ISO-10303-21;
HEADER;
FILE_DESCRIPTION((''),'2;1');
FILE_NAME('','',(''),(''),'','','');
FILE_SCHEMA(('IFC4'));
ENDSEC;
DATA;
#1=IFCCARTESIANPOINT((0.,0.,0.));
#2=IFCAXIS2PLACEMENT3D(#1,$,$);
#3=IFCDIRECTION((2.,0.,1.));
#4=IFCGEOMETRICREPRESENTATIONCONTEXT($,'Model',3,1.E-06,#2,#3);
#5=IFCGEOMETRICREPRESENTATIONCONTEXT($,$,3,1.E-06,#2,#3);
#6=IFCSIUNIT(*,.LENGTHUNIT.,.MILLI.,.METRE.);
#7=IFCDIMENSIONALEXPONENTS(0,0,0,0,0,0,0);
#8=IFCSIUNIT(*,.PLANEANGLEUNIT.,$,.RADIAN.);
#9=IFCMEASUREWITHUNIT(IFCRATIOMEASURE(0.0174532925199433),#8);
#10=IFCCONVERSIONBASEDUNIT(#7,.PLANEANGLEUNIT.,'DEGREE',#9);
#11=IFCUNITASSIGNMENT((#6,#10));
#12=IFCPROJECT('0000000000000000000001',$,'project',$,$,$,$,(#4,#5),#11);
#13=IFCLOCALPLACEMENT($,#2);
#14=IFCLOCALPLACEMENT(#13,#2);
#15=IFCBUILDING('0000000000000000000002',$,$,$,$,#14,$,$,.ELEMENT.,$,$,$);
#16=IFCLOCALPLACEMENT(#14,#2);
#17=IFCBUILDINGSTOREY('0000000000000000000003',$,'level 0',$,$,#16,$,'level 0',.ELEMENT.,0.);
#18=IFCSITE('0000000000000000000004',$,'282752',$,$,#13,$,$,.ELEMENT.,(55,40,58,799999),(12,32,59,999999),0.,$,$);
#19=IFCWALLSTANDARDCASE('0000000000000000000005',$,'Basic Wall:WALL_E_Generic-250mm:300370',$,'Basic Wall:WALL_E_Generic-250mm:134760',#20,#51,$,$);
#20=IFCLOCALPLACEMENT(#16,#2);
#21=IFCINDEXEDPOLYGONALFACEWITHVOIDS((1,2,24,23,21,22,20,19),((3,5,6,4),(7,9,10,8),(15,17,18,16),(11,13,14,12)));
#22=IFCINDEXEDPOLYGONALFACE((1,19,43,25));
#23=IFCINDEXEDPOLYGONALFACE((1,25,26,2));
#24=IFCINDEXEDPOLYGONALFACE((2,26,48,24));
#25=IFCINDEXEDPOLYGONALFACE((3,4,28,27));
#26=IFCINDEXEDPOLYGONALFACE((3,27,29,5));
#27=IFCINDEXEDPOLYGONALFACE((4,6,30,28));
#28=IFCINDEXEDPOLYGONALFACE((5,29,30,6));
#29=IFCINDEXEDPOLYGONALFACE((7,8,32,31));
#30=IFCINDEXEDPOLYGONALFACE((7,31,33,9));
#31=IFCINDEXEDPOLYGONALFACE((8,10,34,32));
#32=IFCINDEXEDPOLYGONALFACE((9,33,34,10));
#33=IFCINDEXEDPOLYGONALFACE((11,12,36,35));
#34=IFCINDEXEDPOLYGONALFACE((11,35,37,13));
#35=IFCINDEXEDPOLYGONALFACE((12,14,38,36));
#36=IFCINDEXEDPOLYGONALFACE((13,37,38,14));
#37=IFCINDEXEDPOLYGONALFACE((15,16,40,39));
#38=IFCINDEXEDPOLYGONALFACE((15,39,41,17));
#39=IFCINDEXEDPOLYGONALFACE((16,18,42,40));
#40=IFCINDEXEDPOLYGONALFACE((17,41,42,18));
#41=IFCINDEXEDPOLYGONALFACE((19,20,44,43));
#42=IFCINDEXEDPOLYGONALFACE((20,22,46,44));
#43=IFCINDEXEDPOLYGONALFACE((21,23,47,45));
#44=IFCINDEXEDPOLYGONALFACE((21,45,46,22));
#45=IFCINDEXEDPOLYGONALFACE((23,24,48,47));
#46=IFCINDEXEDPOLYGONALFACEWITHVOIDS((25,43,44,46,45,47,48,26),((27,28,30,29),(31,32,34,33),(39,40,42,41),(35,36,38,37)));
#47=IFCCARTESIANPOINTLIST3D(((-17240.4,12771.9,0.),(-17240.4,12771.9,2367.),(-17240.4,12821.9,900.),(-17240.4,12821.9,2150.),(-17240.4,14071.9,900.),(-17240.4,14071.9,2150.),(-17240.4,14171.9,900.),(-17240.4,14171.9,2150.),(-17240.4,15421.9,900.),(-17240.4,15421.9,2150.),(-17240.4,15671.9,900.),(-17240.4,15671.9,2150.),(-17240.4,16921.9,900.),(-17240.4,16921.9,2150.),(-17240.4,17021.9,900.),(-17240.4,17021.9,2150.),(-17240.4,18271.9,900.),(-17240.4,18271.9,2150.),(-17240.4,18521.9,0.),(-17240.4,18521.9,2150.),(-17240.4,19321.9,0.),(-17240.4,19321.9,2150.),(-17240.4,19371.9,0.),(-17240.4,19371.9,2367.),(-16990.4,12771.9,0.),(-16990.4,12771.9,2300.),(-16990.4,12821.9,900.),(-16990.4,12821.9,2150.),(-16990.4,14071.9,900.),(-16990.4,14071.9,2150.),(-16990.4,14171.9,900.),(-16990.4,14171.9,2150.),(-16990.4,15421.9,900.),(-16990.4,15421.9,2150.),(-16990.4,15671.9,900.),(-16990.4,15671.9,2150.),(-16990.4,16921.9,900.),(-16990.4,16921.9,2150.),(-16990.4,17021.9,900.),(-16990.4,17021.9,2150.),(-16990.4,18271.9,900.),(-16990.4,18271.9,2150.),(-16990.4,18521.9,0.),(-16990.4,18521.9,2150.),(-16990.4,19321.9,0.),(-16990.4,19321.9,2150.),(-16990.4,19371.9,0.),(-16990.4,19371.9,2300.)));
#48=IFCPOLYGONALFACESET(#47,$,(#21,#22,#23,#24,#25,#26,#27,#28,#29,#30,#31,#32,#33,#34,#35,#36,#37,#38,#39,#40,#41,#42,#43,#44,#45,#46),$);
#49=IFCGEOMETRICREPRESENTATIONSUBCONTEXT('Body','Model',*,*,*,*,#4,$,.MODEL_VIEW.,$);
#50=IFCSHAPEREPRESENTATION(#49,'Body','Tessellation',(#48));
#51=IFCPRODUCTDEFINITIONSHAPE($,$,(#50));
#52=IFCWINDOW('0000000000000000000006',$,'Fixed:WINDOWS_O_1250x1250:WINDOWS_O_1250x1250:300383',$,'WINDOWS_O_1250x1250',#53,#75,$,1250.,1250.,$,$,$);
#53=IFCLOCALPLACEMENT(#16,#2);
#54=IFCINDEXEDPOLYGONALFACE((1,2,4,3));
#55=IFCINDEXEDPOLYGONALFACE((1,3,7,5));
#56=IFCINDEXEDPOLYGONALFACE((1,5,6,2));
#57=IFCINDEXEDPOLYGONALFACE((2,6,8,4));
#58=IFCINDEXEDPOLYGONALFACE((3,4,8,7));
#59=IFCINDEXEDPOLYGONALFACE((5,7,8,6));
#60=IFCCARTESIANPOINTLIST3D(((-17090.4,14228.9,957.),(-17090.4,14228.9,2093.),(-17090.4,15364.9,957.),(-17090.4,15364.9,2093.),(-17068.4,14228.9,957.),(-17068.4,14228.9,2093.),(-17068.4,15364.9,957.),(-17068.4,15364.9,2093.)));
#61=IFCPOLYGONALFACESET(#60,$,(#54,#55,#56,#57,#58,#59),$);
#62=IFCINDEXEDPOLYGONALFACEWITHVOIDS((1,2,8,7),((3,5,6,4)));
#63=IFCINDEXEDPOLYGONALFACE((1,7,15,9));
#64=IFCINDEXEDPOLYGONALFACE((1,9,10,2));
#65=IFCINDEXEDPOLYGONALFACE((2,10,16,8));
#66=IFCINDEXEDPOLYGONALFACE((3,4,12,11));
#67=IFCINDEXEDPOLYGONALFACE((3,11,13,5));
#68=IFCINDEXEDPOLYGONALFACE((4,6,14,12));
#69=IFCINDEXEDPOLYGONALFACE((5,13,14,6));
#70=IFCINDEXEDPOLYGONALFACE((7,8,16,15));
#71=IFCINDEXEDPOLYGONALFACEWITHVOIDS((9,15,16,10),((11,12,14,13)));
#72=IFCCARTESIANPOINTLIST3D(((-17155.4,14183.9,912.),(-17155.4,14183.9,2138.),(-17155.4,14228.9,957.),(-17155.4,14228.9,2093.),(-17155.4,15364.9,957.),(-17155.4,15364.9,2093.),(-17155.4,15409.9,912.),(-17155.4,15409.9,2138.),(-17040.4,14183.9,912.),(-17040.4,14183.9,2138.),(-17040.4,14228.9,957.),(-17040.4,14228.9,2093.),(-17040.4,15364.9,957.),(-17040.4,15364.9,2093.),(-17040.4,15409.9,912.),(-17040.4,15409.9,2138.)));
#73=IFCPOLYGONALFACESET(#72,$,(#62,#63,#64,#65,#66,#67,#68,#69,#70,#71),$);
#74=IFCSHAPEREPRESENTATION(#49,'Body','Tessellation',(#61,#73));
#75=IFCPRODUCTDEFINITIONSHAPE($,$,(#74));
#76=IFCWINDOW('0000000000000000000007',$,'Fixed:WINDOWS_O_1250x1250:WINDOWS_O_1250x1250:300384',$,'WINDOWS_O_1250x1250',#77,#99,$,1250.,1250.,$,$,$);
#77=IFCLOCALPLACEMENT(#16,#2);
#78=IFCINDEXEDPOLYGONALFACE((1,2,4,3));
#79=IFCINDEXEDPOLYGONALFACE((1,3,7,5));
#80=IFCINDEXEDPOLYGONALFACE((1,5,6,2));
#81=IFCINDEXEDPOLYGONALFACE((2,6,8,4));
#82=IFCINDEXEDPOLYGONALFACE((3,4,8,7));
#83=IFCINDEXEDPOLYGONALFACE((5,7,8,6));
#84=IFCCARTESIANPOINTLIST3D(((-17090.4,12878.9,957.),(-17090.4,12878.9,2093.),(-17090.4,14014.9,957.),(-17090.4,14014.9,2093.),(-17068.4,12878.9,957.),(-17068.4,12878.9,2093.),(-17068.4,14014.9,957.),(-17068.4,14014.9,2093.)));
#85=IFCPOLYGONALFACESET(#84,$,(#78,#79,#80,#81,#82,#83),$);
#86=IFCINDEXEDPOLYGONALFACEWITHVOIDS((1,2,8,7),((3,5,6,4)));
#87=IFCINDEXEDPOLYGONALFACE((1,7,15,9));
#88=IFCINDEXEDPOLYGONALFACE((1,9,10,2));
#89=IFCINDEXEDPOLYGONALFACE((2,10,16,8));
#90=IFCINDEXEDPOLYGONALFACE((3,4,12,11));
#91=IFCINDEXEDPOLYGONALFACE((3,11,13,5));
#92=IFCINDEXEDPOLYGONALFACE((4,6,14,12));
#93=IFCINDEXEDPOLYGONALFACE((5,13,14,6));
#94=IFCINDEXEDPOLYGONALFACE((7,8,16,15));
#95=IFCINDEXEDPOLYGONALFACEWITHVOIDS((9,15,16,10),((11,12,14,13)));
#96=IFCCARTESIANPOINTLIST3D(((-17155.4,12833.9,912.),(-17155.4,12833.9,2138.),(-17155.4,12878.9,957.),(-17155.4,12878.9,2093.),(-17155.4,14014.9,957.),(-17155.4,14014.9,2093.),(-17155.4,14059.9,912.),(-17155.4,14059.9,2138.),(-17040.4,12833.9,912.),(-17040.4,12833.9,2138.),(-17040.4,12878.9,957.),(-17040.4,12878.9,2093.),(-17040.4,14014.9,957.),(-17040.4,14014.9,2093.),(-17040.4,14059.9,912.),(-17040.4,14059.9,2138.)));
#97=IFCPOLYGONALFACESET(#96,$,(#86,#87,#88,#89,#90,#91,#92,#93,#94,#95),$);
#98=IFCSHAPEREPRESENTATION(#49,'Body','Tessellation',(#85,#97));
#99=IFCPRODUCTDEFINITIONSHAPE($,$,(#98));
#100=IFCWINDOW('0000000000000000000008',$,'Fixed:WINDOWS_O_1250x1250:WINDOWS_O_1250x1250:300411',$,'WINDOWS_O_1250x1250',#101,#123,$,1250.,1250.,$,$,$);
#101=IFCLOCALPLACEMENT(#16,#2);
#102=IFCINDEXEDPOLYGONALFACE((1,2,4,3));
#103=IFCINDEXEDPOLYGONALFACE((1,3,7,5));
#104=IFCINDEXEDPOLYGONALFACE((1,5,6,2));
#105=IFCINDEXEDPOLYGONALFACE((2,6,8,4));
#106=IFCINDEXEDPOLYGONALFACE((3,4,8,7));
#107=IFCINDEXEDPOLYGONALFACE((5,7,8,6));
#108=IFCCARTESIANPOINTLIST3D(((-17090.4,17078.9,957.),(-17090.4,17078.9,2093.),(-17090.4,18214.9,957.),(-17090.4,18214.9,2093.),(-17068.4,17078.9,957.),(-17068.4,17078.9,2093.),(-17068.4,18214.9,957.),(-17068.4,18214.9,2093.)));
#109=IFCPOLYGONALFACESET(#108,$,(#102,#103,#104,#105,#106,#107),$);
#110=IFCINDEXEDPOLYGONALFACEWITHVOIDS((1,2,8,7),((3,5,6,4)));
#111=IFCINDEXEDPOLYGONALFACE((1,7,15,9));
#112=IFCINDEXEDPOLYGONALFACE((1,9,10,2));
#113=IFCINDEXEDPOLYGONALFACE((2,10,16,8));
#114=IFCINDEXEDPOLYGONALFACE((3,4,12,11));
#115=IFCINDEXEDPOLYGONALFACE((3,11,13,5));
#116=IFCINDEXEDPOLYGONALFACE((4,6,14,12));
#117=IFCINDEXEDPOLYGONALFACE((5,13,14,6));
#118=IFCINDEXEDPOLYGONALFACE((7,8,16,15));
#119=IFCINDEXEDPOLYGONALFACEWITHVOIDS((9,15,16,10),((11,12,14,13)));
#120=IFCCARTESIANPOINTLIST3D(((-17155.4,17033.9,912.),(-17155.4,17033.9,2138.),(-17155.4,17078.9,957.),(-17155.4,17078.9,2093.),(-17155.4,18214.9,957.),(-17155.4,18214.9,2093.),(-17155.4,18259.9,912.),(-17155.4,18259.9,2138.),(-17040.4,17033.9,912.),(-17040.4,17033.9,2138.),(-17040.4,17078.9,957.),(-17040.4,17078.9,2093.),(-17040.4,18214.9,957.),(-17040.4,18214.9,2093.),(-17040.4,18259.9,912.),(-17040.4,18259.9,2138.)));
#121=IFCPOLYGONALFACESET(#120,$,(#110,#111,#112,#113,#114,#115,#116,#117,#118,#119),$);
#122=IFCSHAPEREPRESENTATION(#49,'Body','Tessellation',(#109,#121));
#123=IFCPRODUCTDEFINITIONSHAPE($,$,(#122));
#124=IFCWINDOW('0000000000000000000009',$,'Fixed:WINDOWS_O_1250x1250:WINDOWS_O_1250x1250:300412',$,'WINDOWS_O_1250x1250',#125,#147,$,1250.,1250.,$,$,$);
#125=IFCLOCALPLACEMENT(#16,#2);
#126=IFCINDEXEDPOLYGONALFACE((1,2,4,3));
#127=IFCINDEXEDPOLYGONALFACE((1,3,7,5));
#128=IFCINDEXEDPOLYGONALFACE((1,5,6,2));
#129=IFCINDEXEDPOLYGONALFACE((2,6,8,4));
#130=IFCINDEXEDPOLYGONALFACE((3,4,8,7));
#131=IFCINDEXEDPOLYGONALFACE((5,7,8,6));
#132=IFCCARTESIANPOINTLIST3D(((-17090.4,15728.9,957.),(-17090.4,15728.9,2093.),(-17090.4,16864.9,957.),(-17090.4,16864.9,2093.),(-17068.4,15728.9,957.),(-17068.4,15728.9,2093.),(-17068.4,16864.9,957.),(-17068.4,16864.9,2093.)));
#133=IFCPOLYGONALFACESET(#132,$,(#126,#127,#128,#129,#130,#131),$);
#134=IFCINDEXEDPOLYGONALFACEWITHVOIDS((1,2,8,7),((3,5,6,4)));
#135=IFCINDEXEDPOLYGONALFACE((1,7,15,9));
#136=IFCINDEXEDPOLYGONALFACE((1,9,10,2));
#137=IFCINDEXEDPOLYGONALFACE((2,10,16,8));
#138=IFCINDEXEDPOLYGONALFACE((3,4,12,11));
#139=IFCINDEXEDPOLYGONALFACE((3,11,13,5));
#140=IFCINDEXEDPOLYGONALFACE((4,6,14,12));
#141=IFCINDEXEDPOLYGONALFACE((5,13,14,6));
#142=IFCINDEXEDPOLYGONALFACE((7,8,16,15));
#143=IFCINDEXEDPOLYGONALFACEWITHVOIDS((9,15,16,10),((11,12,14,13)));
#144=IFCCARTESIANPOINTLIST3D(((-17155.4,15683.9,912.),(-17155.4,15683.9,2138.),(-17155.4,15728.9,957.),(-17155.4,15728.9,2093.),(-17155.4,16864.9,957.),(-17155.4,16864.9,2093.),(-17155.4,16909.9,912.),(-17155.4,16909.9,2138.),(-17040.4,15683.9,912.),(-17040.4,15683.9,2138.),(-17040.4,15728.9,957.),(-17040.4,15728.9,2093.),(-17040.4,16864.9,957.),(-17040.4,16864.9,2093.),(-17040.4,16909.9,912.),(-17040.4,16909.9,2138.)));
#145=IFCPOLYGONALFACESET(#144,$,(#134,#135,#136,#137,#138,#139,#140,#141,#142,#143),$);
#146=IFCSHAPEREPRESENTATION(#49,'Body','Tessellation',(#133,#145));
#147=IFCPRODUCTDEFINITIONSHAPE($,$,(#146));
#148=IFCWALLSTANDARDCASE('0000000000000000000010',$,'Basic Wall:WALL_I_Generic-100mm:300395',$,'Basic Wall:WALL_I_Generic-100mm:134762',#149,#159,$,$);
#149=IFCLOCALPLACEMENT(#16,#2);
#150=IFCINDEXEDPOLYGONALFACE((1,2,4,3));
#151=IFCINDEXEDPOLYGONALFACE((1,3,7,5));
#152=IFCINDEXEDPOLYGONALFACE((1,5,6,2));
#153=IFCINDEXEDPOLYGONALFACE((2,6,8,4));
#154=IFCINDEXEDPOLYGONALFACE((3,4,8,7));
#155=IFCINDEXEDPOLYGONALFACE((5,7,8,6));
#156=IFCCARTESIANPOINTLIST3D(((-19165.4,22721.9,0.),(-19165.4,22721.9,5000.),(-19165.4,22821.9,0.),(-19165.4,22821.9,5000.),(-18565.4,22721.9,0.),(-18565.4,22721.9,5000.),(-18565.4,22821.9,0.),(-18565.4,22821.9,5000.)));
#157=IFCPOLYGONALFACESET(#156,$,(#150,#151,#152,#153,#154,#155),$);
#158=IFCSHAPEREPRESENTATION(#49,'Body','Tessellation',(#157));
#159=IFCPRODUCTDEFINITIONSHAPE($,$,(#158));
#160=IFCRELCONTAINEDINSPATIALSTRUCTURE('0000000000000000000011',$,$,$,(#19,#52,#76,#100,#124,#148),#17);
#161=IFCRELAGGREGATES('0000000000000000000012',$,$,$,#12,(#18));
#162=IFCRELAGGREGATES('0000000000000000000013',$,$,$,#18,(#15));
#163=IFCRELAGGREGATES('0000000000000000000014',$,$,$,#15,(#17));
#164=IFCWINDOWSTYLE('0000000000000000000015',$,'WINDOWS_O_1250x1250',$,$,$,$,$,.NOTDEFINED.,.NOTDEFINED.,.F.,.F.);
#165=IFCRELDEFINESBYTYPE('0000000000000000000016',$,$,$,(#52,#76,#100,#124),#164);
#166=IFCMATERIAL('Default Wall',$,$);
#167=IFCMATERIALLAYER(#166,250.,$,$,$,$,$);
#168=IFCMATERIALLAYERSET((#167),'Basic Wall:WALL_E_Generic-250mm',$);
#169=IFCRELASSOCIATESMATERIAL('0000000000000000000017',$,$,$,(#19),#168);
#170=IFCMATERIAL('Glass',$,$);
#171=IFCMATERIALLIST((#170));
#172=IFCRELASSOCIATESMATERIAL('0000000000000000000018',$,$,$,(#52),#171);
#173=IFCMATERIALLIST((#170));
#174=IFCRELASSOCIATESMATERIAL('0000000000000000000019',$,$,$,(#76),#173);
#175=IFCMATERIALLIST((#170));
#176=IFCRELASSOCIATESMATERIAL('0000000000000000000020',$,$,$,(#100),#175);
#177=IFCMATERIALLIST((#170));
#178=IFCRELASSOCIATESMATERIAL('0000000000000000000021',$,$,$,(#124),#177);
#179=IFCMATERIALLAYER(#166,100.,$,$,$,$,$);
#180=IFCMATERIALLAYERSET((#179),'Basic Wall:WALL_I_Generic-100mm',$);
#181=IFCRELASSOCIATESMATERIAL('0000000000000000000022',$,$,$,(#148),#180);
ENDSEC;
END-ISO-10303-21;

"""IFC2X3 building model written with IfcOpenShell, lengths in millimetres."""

from ifc_helpers import new_model, entity, si_unit, converted_unit, direction, frame, frame_2d, origin, origin_2d_with_axis, place, context, subcontext, project, spatial, polyline, rectangle, outline, extrude, clip, bounded_halfspace, source, transform, mapped, material, material_list, layer, layer_set, layer_usage, type_object, type_shapes, element, fill, save


model = new_model("IFC2X3")

# Units and contexts
model_context = context("Model", 3, precision=1e-06, world=origin(), true_north=direction((2.0, 0.0, 1.0)))
context_of_model = context(None, 3, precision=1e-06, world=origin(), true_north=direction((2.0, 0.0, 1.0)))
body_context = subcontext(model_context, "Body", "Model", "MODEL_VIEW")
ifc_project = project(units=[si_unit("LENGTHUNIT", "METRE", prefix="MILLI"), converted_unit("PLANEANGLEUNIT", "DEGREE", entity("IfcRatioMeasure", 0.0174532925199433), si_unit("PLANEANGLEUNIT", "RADIAN"), dimensions=[0, 0, 0, 0, 0, 0, 0])], contexts=[model_context, context_of_model])

# Site, building, storey
site_placement = place(None, origin())
site = spatial("IfcSite", under=ifc_project, at=site_placement, Name="282752", CompositionType="ELEMENT", RefLatitude=(55, 40, 58, 799999), RefLongitude=(12, 32, 59, 999999), RefElevation=0.0)
building_placement = place(site_placement, origin())
building = spatial("IfcBuilding", under=site, at=building_placement, CompositionType="ELEMENT")
storey_placement = place(building_placement, origin())
storey = spatial("IfcBuildingStorey", under=building, at=storey_placement, Name="level 0", LongName="level 0", CompositionType="ELEMENT", Elevation=0.0)

# Shared definitions
ifc_material_1 = material(Name="Default Wall")
ifc_layer_1 = layer(ifc_material_1, 100.0)
ifc_layer_set_1 = layer_set([ifc_layer_1], Name="Basic Wall:WALL_I_Generic-100mm")

# Shared definitions
ifc_layer_2 = layer(ifc_material_1, 250.0)
ifc_layer_set_2 = layer_set([ifc_layer_2], Name="Basic Wall:WALL_E_Generic-250mm")

# Wall, openings, windows
ifc_layer_usage_1 = layer_usage(ifc_layer_set_2, "AXIS2", "NEGATIVE", 125.0)
wall_1_placement = place(storey_placement, frame((-17115.4, 12771.9, 0.0), z_axis=(0.0, 0.0, 1.0), x_axis=(0.0, 1.0, 0.0)))
wall_1 = element("IfcWallStandardCase", 1, at=wall_1_placement, inside=storey, material=ifc_layer_usage_1, Name="Basic Wall:WALL_E_Generic-250mm:300370", ObjectType="Basic Wall:WALL_E_Generic-250mm:134760", context=body_context, shape_type="Clipping", body=[
    clip(extrude(rectangle(XDim=6600.0, YDim=250.0, at=frame_2d((3300.0, 0.0), x_axis=(-1.0, 0.0))), origin(), (0.0, 0.0, 1.0), 2593.3), bounded_halfspace(frame((0.0, -125.0, 2300.0), z_axis=(0.0, -0.258819, 0.965926), x_axis=(1.0, 0.0, 0.0)), False, frame((0.0, -125.0, 2300.0)), polyline([(0.0, 0.0), (6600.0, 0.0), (6600.0, 250.0), (5675.0, 250.0), (5575.0, 250.0), (2825.0, 250.0), (2725.0, 250.0), (0.0, 250.0), (0.0, 0.0)]))),
])
opening_1_placement = place(wall_1_placement, frame((1400.0, -125.0, 900.0)))
opening_1 = element("IfcOpeningElement", 2, at=opening_1_placement, cuts=wall_1, ObjectType="Opening", context=body_context, shape_type="SweptSolid", body=[
    extrude(rectangle(XDim=1250.0, YDim=1250.0, at=frame_2d((625.0, 625.0), x_axis=(1.0, 0.0))), frame((0.0, 0.0, 0.0), z_axis=(0.0, 1.0, 0.0), x_axis=(0.0, 0.0, 1.0)), (0.0, 0.0, 1.0), 250.0),
])
opening_2_placement = place(wall_1_placement, frame((50.0, -125.0, 900.0)))
opening_2 = element("IfcOpeningElement", 3, at=opening_2_placement, cuts=wall_1, ObjectType="Opening", context=body_context, shape_type="SweptSolid", body=[
    extrude(rectangle(XDim=1250.0, YDim=1250.0, at=frame_2d((625.0, 625.0), x_axis=(1.0, 0.0))), frame((0.0, 0.0, 0.0), z_axis=(0.0, 1.0, 0.0), x_axis=(0.0, 0.0, 1.0)), (0.0, 0.0, 1.0), 250.0),
])
opening_3_placement = place(wall_1_placement, frame((6550.0, 125.0, 0.0)))
element("IfcOpeningElement", 4, at=opening_3_placement, cuts=wall_1, ObjectType="Opening", context=body_context, shape_type="SweptSolid", body=[
    extrude(rectangle(XDim=2150.0, YDim=800.0, at=frame_2d((1075.0, 400.0), x_axis=(1.0, 0.0))), frame((0.0, 0.0, 0.0), z_axis=(0.0, -1.0, 0.0), x_axis=(0.0, 0.0, 1.0)), (0.0, 0.0, 1.0), 250.0),
])
opening_4_placement = place(wall_1_placement, frame((4250.0, -125.0, 900.0)))
opening_4 = element("IfcOpeningElement", 5, at=opening_4_placement, cuts=wall_1, ObjectType="Opening", context=body_context, shape_type="SweptSolid", body=[
    extrude(rectangle(XDim=1250.0, YDim=1250.0, at=frame_2d((625.0, 625.0), x_axis=(1.0, 0.0))), frame((0.0, 0.0, 0.0), z_axis=(0.0, 1.0, 0.0), x_axis=(0.0, 0.0, 1.0)), (0.0, 0.0, 1.0), 250.0),
])
opening_5_placement = place(wall_1_placement, frame((2900.0, -125.0, 900.0)))
opening_5 = element("IfcOpeningElement", 6, at=opening_5_placement, cuts=wall_1, ObjectType="Opening", context=body_context, shape_type="SweptSolid", body=[
    extrude(rectangle(XDim=1250.0, YDim=1250.0, at=frame_2d((625.0, 625.0), x_axis=(1.0, 0.0))), frame((0.0, 0.0, 0.0), z_axis=(0.0, 1.0, 0.0), x_axis=(0.0, 0.0, 1.0)), (0.0, 0.0, 1.0), 250.0),
])
ifc_material_2 = material(Name="Glass")
ifc_material_list_1 = material_list([ifc_material_2])
window_style = type_object("IfcWindowStyle", Name="WINDOWS_O_1250x1250", ConstructionType="NOTDEFINED", OperationType="NOTDEFINED", ParameterTakesPrecedence=False, Sizeable=False)
shared_shape = source(origin(), body_context, "Body", "SweptSolid", [
    extrude(rectangle(XDim=1136.0, YDim=22.0, at=origin_2d_with_axis()), frame((625.0, 161.0, 57.0), z_axis=(0.0, 0.0, 1.0), x_axis=(-1.0, 0.0, 0.0)), (0.0, 0.0, 1.0), 1136.0),
    extrude(outline(polyline([(-613.0, -613.0), (613.0, -613.0), (613.0, 613.0), (-613.0, 613.0), (-613.0, -613.0)]), holes=[polyline([(568.0, -568.0), (-568.0, -568.0), (-568.0, 568.0), (568.0, 568.0), (568.0, -568.0)])]), frame((625.0, 85.0, 625.0), z_axis=(0.0, 1.0, 0.0), x_axis=(0.0, 0.0, 1.0)), (0.0, 0.0, 1.0), 115.0),
])
type_shapes(window_style, [shared_shape])
window_1_placement = place(opening_1_placement, frame((1250.0, 250.0, 0.0), z_axis=(0.0, 0.0, 1.0), x_axis=(-1.0, 0.0, 0.0)))
window_1 = element("IfcWindow", 7, at=window_1_placement, inside=storey, type_object=window_style, material=ifc_material_list_1, Name="Fixed:WINDOWS_O_1250x1250:WINDOWS_O_1250x1250:300383", ObjectType="WINDOWS_O_1250x1250", OverallHeight=1250.0, OverallWidth=1250.0, context=body_context, shape_type="MappedRepresentation", body=[
    mapped(shared_shape, transform((0.0, 0.0, 0.0), scale=1.0)),
])
fill(opening_1, window_1)
ifc_material_list_2 = material_list([ifc_material_2])
window_2_placement = place(opening_2_placement, frame((1250.0, 250.0, 0.0), z_axis=(0.0, 0.0, 1.0), x_axis=(-1.0, 0.0, 0.0)))
window_2 = element("IfcWindow", 8, at=window_2_placement, inside=storey, type_object=window_style, material=ifc_material_list_2, Name="Fixed:WINDOWS_O_1250x1250:WINDOWS_O_1250x1250:300384", ObjectType="WINDOWS_O_1250x1250", OverallHeight=1250.0, OverallWidth=1250.0, context=body_context, shape_type="MappedRepresentation", body=[
    mapped(shared_shape, transform((0.0, 0.0, 0.0), scale=1.0)),
])
fill(opening_2, window_2)
ifc_material_list_3 = material_list([ifc_material_2])
window_3_placement = place(opening_4_placement, frame((1250.0, 250.0, 0.0), z_axis=(0.0, 0.0, 1.0), x_axis=(-1.0, 0.0, 0.0)))
window_3 = element("IfcWindow", 9, at=window_3_placement, inside=storey, type_object=window_style, material=ifc_material_list_3, Name="Fixed:WINDOWS_O_1250x1250:WINDOWS_O_1250x1250:300411", ObjectType="WINDOWS_O_1250x1250", OverallHeight=1250.0, OverallWidth=1250.0, context=body_context, shape_type="MappedRepresentation", body=[
    mapped(shared_shape, transform((0.0, 0.0, 0.0), scale=1.0)),
])
fill(opening_4, window_3)
ifc_material_list_4 = material_list([ifc_material_2])
window_4_placement = place(opening_5_placement, frame((1250.0, 250.0, 0.0), z_axis=(0.0, 0.0, 1.0), x_axis=(-1.0, 0.0, 0.0)))
window_4 = element("IfcWindow", 10, at=window_4_placement, inside=storey, type_object=window_style, material=ifc_material_list_4, Name="Fixed:WINDOWS_O_1250x1250:WINDOWS_O_1250x1250:300412", ObjectType="WINDOWS_O_1250x1250", OverallHeight=1250.0, OverallWidth=1250.0, context=body_context, shape_type="MappedRepresentation", body=[
    mapped(shared_shape, transform((0.0, 0.0, 0.0), scale=1.0)),
])
fill(opening_5, window_4)

# Wall
ifc_layer_usage_2 = layer_usage(ifc_layer_set_1, "AXIS2", "NEGATIVE", 50.0)
wall_2_placement = place(storey_placement, frame((-18565.4, 22771.9, 0.0), z_axis=(0.0, 0.0, 1.0), x_axis=(-1.0, 0.0, 0.0)))
element("IfcWallStandardCase", 11, at=wall_2_placement, inside=storey, material=ifc_layer_usage_2, Name="Basic Wall:WALL_I_Generic-100mm:300395", ObjectType="Basic Wall:WALL_I_Generic-100mm:134762", context=body_context, shape_type="SweptSolid", body=[
    extrude(rectangle(XDim=600.0, YDim=100.0, at=frame_2d((300.0, 0.0), x_axis=(-1.0, 0.0))), origin(), (0.0, 0.0, 1.0), 5000.0),
])

save(model, "model.ifc")
